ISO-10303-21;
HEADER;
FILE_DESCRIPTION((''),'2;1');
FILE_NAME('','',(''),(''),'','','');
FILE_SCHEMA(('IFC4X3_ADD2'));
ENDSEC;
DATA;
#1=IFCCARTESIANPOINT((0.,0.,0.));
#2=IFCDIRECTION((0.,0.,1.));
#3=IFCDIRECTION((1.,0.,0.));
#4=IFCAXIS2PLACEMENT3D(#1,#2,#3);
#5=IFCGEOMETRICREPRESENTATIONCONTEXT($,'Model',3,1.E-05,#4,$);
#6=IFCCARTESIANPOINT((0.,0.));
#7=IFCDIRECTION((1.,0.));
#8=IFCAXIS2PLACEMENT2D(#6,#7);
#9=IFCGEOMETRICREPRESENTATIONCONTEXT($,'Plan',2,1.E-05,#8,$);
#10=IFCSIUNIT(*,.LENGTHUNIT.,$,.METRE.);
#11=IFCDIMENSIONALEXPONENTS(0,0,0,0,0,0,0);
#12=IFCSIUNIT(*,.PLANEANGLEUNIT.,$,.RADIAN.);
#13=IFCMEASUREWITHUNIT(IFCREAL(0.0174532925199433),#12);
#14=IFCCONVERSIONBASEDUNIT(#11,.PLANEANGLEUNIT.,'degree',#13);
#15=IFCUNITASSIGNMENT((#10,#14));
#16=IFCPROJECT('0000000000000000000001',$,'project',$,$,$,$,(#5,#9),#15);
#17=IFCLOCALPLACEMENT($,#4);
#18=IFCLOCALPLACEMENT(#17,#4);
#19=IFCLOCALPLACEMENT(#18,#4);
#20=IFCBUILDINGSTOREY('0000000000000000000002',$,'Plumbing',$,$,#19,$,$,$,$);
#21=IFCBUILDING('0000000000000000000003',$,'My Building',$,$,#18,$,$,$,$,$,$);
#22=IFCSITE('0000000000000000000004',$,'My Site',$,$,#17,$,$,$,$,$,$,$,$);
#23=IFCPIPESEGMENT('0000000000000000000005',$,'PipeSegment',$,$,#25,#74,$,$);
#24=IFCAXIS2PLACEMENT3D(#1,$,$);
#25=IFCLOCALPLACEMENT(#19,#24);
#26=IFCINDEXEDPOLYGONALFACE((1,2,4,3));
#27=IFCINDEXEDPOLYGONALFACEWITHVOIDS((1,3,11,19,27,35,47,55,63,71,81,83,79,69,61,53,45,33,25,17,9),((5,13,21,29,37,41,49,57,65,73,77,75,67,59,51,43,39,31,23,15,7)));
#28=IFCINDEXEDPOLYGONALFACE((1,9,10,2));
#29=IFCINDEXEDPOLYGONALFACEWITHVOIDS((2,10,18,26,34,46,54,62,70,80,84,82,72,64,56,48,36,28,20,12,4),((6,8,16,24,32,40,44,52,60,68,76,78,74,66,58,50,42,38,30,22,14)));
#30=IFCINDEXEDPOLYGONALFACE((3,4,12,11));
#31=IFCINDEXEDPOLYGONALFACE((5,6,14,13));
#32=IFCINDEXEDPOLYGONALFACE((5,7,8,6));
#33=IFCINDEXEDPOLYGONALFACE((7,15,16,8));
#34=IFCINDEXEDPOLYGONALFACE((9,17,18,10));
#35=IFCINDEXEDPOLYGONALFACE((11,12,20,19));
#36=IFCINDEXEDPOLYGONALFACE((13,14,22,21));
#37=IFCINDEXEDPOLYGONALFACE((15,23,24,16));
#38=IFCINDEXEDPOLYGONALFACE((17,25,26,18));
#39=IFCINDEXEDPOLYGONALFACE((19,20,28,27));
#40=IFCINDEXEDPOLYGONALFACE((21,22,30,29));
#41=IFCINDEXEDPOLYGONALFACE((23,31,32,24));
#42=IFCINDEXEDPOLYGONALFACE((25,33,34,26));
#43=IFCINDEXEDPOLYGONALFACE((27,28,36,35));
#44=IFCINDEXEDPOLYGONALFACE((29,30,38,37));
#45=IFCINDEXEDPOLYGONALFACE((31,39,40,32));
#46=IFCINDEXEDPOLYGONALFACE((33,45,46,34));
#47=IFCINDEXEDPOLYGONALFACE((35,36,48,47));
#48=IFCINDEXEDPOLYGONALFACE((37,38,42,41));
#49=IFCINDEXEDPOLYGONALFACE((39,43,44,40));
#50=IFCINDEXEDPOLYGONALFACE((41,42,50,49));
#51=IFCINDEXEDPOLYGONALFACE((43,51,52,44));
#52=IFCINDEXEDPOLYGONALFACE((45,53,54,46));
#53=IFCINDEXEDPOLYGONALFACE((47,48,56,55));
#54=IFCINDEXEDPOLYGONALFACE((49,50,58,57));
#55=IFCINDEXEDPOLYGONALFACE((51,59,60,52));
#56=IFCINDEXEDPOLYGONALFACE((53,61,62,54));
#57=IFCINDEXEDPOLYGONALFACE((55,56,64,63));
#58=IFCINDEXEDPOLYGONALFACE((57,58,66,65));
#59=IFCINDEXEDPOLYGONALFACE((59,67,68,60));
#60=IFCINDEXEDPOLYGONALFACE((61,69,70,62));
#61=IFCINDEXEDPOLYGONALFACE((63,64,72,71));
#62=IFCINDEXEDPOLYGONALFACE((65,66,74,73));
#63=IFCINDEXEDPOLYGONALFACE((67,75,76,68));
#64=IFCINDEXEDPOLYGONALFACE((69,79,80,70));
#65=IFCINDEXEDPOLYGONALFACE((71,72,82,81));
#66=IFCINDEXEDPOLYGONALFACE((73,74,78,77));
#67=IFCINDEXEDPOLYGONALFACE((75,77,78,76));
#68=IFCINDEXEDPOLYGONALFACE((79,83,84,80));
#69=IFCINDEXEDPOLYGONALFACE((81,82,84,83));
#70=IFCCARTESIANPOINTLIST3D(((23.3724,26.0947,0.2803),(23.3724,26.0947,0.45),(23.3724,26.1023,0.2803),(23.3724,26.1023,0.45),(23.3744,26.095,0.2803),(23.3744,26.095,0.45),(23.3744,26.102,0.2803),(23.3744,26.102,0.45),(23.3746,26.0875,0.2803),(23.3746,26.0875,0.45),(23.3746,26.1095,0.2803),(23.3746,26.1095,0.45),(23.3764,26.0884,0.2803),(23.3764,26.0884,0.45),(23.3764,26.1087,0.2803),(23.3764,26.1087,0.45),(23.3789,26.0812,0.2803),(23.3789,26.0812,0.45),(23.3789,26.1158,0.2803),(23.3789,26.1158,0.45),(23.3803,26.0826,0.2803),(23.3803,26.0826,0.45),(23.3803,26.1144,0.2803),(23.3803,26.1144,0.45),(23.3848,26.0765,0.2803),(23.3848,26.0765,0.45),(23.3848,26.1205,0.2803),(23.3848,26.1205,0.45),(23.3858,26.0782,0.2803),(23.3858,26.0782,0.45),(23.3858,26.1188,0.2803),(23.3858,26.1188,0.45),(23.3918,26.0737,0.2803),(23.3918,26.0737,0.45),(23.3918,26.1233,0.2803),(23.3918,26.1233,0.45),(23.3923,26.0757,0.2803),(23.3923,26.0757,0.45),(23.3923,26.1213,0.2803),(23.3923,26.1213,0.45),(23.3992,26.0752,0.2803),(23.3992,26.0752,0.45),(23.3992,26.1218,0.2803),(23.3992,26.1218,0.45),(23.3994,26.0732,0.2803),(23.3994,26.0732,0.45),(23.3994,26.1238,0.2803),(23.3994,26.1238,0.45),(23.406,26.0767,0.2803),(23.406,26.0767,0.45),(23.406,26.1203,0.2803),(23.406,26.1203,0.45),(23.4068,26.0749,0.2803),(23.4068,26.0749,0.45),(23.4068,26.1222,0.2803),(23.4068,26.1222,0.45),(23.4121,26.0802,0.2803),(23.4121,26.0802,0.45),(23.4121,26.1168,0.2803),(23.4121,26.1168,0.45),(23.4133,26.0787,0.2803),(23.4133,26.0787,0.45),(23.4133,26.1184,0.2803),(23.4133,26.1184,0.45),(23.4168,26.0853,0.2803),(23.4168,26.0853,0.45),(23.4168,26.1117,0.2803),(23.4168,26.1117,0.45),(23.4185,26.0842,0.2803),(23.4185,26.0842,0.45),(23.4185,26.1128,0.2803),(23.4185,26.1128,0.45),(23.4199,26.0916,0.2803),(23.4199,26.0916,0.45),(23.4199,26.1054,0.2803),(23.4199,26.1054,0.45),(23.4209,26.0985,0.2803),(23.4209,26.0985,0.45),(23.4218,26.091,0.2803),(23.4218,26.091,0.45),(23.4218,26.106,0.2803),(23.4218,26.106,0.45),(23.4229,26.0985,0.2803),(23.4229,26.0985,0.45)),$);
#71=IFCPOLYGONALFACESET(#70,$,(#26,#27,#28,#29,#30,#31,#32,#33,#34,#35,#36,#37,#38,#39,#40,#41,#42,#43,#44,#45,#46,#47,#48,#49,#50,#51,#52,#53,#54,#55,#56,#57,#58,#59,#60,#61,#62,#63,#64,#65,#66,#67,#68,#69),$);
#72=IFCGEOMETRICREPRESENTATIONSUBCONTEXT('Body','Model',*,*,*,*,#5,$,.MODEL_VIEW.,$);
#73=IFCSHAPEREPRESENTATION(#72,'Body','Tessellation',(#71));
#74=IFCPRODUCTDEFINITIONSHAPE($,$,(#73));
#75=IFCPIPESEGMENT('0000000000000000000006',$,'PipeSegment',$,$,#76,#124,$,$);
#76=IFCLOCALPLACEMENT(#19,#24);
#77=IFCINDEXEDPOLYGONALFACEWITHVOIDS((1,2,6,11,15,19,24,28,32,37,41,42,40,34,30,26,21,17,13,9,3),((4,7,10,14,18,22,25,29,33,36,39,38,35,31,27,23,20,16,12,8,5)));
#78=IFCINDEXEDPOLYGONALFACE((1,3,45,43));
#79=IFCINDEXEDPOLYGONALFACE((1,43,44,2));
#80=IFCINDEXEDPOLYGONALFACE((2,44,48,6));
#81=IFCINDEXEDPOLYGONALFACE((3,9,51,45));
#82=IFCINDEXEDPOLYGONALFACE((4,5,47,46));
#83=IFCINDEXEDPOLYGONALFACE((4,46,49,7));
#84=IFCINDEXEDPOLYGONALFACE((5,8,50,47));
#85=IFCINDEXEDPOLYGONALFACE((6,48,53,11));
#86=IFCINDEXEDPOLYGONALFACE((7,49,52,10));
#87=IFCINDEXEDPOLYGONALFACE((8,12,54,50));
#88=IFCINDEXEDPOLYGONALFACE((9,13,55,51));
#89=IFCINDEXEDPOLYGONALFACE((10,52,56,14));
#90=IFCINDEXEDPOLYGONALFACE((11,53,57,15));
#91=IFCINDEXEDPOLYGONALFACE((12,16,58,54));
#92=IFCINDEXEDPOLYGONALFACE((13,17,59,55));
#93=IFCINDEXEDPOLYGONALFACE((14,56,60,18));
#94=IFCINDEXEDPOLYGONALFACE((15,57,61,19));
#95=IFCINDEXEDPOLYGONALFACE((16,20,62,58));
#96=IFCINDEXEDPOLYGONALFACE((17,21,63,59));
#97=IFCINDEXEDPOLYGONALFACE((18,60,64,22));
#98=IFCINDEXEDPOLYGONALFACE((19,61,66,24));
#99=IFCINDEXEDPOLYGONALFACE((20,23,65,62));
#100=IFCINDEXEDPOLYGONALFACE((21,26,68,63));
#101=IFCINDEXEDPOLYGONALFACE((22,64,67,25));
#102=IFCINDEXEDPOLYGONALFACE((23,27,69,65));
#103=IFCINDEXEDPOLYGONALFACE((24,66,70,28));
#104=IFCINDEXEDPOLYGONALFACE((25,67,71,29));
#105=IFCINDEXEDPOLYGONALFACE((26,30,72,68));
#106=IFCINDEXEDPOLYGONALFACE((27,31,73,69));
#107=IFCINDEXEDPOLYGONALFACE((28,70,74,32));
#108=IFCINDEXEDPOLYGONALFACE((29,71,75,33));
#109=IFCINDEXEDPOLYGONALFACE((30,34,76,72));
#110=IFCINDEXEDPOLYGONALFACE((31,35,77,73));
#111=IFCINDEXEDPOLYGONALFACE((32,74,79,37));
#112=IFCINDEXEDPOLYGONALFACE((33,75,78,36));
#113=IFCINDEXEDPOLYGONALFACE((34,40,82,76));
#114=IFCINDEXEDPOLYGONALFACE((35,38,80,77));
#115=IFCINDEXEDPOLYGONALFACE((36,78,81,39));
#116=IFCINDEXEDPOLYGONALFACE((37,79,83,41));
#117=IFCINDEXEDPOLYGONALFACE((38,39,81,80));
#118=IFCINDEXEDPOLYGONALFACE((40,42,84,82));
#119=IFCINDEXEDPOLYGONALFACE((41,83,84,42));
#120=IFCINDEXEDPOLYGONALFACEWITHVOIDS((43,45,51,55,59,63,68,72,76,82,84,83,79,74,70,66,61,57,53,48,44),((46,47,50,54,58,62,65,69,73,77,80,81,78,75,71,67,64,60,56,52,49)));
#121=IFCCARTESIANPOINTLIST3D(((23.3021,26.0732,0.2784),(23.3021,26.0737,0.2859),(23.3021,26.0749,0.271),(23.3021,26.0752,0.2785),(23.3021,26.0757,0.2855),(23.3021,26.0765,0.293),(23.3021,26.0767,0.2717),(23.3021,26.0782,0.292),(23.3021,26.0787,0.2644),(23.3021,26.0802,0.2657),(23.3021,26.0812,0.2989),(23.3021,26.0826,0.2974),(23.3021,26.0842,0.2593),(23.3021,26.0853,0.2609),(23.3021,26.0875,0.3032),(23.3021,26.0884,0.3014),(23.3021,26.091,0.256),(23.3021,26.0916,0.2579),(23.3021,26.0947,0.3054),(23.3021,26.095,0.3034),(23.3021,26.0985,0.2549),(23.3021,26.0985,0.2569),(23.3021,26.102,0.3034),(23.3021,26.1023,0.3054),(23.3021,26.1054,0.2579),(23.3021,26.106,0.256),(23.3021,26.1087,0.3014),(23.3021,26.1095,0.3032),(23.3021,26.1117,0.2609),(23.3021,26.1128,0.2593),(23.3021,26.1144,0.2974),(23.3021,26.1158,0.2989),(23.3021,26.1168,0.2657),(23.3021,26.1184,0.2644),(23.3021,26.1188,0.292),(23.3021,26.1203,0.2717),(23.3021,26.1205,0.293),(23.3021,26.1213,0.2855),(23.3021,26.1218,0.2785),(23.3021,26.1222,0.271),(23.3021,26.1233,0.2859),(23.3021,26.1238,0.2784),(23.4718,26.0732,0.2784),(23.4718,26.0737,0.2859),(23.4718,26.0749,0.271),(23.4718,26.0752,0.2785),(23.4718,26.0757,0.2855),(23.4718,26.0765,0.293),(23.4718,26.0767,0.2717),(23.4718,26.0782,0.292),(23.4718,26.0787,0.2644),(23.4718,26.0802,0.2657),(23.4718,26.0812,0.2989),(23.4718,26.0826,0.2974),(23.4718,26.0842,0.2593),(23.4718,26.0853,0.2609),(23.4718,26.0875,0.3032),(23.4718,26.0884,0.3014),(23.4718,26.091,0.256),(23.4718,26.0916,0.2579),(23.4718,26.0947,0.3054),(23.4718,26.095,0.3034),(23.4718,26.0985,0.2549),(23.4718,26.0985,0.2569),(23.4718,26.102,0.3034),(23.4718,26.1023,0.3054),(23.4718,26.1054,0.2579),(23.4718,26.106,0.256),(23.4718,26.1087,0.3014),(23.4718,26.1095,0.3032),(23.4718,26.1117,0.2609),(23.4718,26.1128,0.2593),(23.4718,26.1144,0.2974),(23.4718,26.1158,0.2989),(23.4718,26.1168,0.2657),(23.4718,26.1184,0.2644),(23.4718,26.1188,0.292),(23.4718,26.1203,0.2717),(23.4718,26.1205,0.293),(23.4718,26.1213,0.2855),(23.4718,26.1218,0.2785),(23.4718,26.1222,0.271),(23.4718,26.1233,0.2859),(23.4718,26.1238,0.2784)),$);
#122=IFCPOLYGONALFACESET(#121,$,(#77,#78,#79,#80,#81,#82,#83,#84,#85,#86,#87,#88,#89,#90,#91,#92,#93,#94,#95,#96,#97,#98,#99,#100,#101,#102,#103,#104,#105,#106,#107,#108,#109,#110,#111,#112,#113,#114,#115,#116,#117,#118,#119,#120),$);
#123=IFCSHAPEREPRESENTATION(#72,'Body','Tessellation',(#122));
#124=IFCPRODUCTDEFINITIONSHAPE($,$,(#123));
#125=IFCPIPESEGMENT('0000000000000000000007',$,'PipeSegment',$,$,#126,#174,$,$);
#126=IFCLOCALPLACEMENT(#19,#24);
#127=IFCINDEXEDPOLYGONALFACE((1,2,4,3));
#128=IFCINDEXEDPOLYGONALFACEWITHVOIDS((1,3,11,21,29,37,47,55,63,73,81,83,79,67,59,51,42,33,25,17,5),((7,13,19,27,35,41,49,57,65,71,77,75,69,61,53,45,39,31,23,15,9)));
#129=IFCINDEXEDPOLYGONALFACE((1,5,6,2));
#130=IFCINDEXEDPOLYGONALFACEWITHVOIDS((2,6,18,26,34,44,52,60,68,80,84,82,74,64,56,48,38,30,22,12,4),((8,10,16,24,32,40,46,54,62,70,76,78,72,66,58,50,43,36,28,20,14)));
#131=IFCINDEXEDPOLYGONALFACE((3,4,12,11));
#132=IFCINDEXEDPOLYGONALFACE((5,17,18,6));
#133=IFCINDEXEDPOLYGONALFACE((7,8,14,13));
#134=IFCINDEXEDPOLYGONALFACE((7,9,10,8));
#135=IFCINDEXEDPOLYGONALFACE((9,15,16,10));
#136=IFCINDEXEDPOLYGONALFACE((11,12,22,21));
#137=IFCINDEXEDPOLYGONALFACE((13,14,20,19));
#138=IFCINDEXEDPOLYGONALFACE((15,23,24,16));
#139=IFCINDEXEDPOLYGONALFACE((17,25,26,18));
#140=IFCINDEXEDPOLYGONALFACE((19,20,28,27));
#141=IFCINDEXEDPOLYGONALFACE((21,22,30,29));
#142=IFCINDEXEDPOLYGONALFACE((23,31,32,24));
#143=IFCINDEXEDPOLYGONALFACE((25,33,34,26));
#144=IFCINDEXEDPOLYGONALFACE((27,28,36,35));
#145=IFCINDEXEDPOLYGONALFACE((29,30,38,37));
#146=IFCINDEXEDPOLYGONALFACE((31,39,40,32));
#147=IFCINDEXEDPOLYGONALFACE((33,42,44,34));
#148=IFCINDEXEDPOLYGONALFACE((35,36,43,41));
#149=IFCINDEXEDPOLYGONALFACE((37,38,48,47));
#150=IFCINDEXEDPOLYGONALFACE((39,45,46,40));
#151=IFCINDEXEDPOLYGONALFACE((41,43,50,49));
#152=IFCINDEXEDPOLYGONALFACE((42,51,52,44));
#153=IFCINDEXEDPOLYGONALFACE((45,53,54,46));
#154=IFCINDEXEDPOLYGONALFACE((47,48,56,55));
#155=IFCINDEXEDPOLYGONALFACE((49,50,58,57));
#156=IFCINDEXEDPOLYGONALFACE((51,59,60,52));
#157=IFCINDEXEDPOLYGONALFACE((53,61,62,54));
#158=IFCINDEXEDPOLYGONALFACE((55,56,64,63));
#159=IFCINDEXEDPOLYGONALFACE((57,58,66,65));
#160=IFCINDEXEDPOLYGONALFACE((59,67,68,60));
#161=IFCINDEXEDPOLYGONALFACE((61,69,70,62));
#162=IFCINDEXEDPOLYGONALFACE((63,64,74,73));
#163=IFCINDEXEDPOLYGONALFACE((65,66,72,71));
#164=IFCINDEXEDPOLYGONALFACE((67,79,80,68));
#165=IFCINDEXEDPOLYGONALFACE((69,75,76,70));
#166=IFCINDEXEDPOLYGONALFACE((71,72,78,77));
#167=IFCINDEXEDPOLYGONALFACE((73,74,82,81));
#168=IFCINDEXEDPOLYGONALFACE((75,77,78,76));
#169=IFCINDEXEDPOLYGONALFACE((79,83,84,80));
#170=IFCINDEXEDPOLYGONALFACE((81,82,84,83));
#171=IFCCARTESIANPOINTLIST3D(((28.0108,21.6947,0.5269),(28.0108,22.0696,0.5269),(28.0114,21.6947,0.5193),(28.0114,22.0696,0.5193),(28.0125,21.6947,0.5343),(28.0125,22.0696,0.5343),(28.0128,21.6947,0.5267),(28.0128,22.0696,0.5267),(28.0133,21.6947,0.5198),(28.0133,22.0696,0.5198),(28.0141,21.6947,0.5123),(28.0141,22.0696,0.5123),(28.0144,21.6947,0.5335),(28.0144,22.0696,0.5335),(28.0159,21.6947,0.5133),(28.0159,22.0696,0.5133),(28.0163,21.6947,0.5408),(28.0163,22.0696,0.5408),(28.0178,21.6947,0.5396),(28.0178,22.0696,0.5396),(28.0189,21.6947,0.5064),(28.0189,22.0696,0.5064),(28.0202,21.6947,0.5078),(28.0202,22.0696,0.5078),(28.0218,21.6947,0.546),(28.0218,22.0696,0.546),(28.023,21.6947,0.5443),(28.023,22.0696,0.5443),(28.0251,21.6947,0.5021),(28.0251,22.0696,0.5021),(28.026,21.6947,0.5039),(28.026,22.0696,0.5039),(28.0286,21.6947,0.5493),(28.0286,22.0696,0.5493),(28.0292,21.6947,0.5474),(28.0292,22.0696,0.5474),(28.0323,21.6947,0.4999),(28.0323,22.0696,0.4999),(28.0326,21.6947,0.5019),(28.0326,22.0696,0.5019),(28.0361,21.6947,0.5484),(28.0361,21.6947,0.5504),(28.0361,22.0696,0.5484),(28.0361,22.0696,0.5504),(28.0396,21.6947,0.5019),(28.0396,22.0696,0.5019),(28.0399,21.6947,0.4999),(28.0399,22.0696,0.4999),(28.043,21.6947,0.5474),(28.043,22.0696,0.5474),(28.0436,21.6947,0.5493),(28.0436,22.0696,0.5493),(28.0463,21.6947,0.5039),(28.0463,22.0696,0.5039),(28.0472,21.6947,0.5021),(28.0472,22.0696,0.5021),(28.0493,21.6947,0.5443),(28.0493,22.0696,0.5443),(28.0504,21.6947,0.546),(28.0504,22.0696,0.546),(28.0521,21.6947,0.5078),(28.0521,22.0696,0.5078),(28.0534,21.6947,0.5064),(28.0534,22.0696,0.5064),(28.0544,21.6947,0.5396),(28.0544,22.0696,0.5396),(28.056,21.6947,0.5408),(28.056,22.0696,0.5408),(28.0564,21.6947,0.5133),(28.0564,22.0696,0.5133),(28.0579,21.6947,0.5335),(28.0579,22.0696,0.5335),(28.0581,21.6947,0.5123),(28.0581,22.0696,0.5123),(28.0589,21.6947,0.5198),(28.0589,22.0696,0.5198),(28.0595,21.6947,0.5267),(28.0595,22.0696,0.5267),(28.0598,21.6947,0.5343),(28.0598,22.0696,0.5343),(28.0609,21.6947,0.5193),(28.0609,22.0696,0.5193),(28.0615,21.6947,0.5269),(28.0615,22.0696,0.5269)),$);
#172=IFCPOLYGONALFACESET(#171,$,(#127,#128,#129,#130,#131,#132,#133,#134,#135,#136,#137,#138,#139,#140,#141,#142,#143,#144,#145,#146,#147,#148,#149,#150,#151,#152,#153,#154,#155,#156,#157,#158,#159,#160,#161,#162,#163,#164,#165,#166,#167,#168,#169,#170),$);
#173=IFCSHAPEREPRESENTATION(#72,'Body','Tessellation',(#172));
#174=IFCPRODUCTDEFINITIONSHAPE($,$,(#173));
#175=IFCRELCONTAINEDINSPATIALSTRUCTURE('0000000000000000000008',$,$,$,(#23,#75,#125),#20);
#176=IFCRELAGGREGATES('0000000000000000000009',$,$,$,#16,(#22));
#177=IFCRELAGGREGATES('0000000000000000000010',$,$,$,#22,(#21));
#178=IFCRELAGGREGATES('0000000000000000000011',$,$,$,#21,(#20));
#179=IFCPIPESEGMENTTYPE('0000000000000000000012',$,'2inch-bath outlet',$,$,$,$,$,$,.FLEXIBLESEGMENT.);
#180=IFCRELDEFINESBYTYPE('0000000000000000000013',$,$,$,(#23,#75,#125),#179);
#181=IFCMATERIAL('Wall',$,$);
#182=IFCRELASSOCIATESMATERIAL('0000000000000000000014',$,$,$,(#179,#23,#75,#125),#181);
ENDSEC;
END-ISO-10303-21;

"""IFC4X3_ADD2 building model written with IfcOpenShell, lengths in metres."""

from ifc_helpers import new_model, entity, si_unit, converted_unit, frame, origin_with_axes, origin_2d_with_axis, place, context, subcontext, project, spatial, hollow_circle, extrude, material, material_profile, profile_set, profile_usage, type_object, element, save


model = new_model("IFC4X3_ADD2")

# Units and contexts
model_context = context("Model", 3, precision=1e-05, world=origin_with_axes())
plan_context = context("Plan", 2, precision=1e-05, world=origin_2d_with_axis())
body_context = subcontext(model_context, "Body", "Model", "MODEL_VIEW")
ifc_project = project(units=[si_unit("LENGTHUNIT", "METRE"), converted_unit("PLANEANGLEUNIT", "degree", entity("IfcReal", 0.0174532925199433), si_unit("PLANEANGLEUNIT", "RADIAN"), dimensions=[0, 0, 0, 0, 0, 0, 0])], contexts=[model_context, plan_context])

# Site, building, storey
site_placement = place(None, origin_with_axes())
site = spatial("IfcSite", under=ifc_project, at=site_placement, Name="My Site")
building_placement = place(site_placement, origin_with_axes())
building = spatial("IfcBuilding", under=site, at=building_placement, Name="My Building")
storey_placement = place(building_placement, origin_with_axes())
storey = spatial("IfcBuildingStorey", under=building, at=storey_placement, Name="Plumbing")

# Pipe segments
ifc_material_1 = material(Name="Wall")
ifc_material_profile_1 = material_profile(ifc_material_1, hollow_circle(Radius=0.0254, WallThickness=0.002))
ifc_profile_set_1 = profile_set([ifc_material_profile_1], Name="graywater")
ifc_material_profile_2 = material_profile(ifc_material_1, hollow_circle(Radius=0.0254, WallThickness=0.002))
ifc_profile_set_2 = profile_set([ifc_material_profile_2], Name="graywater")
pipe_segment_type_1 = type_object("IfcPipeSegmentType", Name="2inch-bath outlet", PredefinedType="FLEXIBLESEGMENT", material=ifc_profile_set_2)
ifc_profile_usage_1 = profile_usage(ifc_profile_set_1)
pipe_segment_1_placement = place(storey_placement, frame((23.3975, 26.0985, 0.2803), z_axis=(0.0, 0.0, 1.0), x_axis=(1.0, 0.0, 0.0)))
element("IfcPipeSegment", 1, at=pipe_segment_1_placement, inside=storey, type_object=pipe_segment_type_1, material=ifc_profile_usage_1, Name="PipeSegment", context=body_context, shape_type="SweptSolid", body=[
    extrude(hollow_circle(Radius=0.0254, WallThickness=0.002), origin_with_axes(), (0.0, 0.0, 1.0), 0.1697),
])
ifc_profile_usage_2 = profile_usage(ifc_profile_set_1)
pipe_segment_2_placement = place(storey_placement, frame((23.3021, 26.0985, 0.2803), z_axis=(1.0, 0.0, 0.000001), x_axis=(0.000001, 0.0, -1.0)))
element("IfcPipeSegment", 2, at=pipe_segment_2_placement, inside=storey, type_object=pipe_segment_type_1, material=ifc_profile_usage_2, Name="PipeSegment", context=body_context, shape_type="SweptSolid", body=[
    extrude(hollow_circle(Radius=0.0254, WallThickness=0.002), origin_with_axes(), (0.0, 0.0, 1.0), 0.1697),
])
ifc_profile_usage_3 = profile_usage(ifc_profile_set_1)
pipe_segment_3_placement = place(storey_placement, frame((28.0361, 22.0696, 0.525), z_axis=(0.0, -1.0, 0.0), x_axis=(0.0, 0.0, 1.0)))
element("IfcPipeSegment", 3, at=pipe_segment_3_placement, inside=storey, type_object=pipe_segment_type_1, material=ifc_profile_usage_3, Name="PipeSegment", context=body_context, shape_type="SweptSolid", body=[
    extrude(hollow_circle(Radius=0.0254, WallThickness=0.002), origin_with_axes(), (0.0, 0.0, 1.0), 0.3749),
])

save(model, "model.ifc")
